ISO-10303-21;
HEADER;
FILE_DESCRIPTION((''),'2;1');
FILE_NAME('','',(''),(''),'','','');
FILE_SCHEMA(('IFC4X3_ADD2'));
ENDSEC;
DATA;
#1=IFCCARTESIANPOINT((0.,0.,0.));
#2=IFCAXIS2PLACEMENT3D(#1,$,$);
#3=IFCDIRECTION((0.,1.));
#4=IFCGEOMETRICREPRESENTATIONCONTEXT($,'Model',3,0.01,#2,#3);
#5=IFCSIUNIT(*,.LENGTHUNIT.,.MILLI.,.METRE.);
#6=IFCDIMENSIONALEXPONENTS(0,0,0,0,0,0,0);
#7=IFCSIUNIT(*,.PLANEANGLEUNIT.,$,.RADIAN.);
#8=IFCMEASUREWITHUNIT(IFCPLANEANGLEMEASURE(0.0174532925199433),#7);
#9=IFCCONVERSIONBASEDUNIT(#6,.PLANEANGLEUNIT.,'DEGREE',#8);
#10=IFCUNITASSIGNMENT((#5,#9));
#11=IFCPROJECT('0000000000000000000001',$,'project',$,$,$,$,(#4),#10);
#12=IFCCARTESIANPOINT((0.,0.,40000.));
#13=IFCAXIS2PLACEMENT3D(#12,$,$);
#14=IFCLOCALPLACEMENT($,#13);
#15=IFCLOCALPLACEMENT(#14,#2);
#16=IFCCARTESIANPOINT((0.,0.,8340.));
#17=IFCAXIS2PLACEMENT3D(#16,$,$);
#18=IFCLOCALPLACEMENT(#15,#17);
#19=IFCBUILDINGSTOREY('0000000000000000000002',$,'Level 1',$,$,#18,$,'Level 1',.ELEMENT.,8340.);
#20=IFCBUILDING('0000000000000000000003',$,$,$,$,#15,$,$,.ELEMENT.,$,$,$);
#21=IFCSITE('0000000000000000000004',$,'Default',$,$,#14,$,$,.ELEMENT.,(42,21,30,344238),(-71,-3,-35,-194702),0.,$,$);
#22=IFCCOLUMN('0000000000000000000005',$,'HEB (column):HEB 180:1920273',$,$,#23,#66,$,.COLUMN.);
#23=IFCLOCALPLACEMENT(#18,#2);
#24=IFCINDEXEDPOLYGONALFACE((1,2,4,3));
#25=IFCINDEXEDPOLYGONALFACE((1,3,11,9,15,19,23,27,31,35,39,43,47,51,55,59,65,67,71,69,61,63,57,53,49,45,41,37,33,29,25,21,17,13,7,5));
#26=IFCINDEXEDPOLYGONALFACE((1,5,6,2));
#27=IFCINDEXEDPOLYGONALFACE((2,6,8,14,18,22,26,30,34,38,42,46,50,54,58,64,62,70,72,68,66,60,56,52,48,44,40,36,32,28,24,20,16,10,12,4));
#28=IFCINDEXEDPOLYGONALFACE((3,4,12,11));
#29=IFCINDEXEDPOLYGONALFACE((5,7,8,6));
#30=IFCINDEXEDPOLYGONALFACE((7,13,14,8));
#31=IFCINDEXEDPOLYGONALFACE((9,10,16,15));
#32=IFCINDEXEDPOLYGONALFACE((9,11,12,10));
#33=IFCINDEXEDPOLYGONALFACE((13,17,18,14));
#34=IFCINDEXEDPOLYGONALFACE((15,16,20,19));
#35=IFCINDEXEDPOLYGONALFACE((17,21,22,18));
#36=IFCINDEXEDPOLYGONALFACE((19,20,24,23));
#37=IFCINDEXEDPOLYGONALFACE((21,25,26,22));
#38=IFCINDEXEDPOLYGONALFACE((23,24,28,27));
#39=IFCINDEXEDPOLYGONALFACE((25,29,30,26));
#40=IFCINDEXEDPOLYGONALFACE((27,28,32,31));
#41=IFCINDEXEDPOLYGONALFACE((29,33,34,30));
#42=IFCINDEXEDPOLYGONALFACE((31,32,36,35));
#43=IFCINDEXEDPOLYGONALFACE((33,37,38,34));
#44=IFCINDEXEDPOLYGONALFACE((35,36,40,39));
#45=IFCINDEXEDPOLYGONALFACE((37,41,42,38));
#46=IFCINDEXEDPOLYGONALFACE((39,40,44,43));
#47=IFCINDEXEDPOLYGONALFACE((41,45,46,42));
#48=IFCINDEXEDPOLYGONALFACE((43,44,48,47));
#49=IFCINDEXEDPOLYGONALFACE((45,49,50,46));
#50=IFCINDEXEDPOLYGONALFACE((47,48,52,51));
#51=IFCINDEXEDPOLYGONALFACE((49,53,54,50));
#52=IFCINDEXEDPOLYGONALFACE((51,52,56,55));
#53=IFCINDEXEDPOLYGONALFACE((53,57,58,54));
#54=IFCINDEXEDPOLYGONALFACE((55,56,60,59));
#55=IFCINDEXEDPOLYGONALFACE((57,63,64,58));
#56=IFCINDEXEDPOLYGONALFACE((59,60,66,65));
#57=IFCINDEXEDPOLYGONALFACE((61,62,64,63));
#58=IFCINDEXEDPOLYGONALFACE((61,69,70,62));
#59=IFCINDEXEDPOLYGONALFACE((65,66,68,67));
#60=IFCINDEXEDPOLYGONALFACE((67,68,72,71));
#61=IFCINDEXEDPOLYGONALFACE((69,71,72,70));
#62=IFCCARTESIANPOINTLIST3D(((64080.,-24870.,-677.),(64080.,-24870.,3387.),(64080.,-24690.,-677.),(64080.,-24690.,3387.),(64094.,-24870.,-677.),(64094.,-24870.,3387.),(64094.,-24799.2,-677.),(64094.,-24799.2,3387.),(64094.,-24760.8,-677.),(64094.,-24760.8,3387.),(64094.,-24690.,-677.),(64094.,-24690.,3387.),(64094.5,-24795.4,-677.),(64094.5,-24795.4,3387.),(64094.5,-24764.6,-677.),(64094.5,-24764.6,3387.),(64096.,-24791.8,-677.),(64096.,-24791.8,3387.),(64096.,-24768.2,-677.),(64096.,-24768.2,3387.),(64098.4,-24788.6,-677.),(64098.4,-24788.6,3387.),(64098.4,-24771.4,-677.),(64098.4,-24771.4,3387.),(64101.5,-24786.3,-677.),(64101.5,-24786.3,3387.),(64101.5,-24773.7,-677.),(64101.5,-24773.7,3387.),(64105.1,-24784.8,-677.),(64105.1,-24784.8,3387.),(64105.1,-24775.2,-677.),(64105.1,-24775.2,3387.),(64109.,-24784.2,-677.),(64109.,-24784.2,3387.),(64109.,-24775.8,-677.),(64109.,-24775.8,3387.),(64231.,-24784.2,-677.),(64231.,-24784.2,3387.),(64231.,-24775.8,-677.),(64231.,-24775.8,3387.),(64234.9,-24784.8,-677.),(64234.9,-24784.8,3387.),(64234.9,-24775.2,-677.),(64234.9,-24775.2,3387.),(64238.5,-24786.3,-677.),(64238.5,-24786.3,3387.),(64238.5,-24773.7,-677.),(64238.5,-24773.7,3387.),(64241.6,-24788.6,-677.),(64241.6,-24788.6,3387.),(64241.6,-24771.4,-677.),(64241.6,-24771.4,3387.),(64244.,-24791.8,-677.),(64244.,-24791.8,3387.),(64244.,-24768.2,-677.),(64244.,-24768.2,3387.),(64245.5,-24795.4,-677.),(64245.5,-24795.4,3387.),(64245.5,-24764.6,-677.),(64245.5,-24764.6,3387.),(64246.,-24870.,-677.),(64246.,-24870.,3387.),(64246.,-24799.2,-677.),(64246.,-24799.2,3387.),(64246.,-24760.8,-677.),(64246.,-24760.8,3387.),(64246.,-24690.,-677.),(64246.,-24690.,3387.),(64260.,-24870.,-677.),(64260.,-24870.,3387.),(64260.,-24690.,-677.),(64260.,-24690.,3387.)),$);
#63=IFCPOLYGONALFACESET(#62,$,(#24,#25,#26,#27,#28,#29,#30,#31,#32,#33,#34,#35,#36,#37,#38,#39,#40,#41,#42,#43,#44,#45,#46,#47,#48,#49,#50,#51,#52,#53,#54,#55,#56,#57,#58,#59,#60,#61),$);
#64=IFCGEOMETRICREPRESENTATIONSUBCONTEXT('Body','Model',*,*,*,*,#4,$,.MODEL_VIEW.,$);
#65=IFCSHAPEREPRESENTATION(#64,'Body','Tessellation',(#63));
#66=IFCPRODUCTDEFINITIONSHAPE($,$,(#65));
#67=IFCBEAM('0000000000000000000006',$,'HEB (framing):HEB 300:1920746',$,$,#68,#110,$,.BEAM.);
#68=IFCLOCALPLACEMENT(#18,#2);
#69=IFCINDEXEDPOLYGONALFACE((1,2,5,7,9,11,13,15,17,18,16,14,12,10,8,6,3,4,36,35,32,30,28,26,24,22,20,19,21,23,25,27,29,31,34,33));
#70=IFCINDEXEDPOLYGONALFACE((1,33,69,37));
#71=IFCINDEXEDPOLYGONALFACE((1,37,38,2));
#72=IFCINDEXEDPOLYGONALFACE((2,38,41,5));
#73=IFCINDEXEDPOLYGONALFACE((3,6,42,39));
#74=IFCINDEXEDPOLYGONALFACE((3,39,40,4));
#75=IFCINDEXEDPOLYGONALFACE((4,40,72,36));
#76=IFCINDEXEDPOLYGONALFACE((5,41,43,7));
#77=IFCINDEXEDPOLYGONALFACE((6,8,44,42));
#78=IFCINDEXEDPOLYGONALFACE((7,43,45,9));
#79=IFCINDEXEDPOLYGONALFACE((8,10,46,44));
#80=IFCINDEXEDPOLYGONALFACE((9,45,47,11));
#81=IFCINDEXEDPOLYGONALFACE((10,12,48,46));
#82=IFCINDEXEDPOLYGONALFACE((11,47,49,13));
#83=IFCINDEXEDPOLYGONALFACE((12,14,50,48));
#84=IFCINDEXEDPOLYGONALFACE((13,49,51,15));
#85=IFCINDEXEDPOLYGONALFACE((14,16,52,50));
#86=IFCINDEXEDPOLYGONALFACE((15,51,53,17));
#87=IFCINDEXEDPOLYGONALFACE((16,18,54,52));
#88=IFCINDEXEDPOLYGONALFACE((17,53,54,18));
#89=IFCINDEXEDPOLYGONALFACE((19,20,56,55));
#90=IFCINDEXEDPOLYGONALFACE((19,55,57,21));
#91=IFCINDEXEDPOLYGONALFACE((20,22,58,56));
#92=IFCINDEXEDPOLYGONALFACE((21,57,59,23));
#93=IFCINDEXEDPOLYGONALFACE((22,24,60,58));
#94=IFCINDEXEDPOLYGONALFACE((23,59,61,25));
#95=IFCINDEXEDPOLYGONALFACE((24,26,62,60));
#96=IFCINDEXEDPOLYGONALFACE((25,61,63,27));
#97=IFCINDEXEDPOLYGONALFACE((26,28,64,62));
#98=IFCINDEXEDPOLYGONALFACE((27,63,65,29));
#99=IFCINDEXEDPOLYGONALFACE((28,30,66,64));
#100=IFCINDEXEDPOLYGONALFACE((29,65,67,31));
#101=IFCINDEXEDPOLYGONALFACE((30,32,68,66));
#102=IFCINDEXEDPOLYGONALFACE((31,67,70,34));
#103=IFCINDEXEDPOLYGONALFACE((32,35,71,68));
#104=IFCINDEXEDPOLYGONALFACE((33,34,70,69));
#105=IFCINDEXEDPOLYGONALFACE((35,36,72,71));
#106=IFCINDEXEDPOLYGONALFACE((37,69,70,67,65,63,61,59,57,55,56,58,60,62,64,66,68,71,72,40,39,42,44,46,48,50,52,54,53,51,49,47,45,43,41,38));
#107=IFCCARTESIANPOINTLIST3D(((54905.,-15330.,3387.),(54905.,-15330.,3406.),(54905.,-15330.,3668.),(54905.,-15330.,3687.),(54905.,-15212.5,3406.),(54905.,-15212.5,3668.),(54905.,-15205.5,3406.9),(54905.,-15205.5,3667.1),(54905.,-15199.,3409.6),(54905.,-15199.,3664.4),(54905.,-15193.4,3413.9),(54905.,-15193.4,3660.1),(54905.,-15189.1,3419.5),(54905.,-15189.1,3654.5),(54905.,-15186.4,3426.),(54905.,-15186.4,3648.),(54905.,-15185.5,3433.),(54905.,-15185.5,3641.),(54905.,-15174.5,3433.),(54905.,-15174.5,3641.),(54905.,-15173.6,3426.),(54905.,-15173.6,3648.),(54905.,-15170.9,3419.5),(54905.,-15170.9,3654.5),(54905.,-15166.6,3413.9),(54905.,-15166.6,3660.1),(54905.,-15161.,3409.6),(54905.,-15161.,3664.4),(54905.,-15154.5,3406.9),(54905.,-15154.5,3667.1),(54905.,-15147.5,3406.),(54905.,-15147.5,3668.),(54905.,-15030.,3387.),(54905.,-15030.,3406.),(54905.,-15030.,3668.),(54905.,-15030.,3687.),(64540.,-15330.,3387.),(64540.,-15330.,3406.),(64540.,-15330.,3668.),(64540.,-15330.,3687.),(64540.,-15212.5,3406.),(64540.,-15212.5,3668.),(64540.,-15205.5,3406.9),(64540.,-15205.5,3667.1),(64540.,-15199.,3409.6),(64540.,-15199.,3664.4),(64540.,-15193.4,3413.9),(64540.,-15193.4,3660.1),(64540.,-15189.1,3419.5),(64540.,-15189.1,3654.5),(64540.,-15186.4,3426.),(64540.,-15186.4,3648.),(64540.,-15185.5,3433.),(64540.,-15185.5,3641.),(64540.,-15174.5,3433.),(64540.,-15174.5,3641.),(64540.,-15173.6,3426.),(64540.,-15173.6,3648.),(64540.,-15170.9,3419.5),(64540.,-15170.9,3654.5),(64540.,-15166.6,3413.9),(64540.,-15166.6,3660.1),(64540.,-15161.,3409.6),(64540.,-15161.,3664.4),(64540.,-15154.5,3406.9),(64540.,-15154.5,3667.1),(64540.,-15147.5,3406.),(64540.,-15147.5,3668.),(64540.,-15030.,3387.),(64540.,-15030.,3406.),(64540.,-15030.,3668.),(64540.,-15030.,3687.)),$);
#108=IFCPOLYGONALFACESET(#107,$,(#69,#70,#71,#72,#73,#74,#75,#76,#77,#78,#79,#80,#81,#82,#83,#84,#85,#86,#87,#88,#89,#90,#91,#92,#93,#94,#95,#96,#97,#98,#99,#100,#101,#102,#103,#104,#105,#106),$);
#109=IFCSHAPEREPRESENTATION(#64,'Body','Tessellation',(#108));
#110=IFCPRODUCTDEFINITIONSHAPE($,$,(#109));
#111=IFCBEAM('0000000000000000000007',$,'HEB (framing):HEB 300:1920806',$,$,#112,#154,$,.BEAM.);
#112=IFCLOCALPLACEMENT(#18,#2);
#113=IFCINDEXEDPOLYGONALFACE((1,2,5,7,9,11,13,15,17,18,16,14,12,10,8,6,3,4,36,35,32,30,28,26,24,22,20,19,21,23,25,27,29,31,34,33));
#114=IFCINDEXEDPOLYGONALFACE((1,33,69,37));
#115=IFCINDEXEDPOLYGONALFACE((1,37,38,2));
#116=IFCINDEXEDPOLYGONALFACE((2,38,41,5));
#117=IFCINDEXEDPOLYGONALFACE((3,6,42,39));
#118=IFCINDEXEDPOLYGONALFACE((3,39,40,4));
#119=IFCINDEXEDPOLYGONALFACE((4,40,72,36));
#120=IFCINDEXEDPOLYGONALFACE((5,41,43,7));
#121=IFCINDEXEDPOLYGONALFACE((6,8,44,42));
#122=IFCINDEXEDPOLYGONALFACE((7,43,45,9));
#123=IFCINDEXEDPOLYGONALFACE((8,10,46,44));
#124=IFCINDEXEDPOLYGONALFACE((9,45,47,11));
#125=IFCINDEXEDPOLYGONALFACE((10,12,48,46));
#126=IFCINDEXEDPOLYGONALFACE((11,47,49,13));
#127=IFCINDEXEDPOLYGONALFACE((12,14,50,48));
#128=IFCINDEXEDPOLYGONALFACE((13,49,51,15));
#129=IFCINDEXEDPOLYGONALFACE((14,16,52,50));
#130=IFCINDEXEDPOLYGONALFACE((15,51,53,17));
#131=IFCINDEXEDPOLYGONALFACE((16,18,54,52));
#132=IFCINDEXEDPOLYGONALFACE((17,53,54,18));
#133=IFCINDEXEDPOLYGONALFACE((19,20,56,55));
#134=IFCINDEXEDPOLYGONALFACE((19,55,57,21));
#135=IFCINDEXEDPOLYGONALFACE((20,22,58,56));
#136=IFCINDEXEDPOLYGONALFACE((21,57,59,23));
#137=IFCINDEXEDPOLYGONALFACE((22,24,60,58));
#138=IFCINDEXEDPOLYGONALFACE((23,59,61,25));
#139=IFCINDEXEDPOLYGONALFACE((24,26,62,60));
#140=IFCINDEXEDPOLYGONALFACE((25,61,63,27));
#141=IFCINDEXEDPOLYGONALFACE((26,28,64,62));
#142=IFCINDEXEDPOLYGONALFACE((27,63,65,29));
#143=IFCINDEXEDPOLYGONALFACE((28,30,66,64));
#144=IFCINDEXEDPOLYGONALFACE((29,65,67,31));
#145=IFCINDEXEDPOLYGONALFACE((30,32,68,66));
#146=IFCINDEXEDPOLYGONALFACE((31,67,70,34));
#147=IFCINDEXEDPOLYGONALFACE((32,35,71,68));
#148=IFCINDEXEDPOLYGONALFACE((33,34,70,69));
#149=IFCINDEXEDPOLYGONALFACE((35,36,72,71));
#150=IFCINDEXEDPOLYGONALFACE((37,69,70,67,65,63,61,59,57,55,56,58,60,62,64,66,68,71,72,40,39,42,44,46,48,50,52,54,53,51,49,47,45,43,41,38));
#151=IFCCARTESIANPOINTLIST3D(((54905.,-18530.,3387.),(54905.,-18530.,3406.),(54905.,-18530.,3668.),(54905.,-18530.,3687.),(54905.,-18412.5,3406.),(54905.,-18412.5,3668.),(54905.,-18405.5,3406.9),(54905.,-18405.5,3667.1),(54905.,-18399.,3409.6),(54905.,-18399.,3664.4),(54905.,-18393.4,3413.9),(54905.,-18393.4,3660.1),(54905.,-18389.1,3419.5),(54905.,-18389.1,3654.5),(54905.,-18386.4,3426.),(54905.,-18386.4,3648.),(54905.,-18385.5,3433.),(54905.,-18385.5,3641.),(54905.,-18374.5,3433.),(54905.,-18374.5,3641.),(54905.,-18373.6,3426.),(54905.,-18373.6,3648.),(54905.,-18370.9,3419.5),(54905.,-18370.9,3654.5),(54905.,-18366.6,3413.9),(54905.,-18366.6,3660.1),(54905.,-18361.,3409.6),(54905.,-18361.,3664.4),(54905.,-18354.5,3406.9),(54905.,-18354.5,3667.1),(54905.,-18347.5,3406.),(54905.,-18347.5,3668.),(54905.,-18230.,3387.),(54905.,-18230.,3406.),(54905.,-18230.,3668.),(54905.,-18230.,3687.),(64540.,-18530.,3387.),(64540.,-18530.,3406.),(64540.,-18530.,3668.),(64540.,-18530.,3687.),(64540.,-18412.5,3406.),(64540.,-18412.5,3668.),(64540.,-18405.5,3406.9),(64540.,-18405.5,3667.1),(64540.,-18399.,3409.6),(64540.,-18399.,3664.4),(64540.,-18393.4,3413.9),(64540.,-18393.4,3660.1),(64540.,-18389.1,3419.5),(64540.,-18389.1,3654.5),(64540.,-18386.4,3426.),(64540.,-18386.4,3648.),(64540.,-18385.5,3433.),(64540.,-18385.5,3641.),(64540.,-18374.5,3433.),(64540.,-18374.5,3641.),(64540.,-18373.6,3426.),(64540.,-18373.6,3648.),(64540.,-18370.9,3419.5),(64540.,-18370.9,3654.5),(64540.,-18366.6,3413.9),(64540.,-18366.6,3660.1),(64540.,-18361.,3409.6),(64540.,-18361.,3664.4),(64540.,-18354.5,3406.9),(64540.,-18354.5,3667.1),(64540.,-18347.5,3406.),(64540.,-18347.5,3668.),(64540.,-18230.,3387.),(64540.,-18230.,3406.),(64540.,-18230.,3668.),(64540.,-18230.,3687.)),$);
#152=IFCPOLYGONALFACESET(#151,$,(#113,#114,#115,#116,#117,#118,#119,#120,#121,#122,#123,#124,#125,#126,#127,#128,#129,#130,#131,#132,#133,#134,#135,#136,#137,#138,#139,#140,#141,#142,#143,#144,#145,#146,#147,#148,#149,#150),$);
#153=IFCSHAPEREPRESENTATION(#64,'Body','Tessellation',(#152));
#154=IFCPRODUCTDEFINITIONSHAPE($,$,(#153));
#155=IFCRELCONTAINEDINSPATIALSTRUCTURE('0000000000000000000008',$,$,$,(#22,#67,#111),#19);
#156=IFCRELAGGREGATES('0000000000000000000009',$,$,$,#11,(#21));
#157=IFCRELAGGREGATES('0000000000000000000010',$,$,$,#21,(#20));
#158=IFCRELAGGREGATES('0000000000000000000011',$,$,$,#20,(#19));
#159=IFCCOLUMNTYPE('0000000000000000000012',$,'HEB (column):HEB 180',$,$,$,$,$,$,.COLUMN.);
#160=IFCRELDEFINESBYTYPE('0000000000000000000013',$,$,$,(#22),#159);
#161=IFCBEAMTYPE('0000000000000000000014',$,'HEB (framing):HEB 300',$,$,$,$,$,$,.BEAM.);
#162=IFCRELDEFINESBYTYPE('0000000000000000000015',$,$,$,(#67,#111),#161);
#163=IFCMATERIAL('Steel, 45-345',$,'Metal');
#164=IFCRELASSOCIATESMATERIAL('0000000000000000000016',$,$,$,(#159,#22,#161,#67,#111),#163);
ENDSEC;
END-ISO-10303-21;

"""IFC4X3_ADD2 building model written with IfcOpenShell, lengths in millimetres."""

from ifc_helpers import new_model, entity, si_unit, converted_unit, direction, frame, frame_2d, origin, origin_2d_with_axis, place, context, subcontext, project, spatial, polyline, circle_curve, parameter, trimmed, segment, composite_curve, i_section, outline, extrude, source, transform, mapped, material, material_profile, profile_set, profile_usage, type_object, type_shapes, element, save


model = new_model("IFC4X3_ADD2")

# Units and contexts
model_context = context("Model", 3, precision=0.01, world=origin(), true_north=direction((0.0, 1.0)))
body_context = subcontext(model_context, "Body", "Model", "MODEL_VIEW")
ifc_project = project(units=[si_unit("LENGTHUNIT", "METRE", prefix="MILLI"), converted_unit("PLANEANGLEUNIT", "DEGREE", entity("IfcPlaneAngleMeasure", 0.0174532925199433), si_unit("PLANEANGLEUNIT", "RADIAN"), dimensions=[0, 0, 0, 0, 0, 0, 0])], contexts=[model_context])

# Site, building, storey
site_placement = place(None, frame((0.0, 0.0, 40000.0)))
site = spatial("IfcSite", under=ifc_project, at=site_placement, Name="Default", CompositionType="ELEMENT", RefLatitude=(42, 21, 30, 344238), RefLongitude=(-71, -3, -35, -194702), RefElevation=0.0)
building_placement = place(site_placement, origin())
building = spatial("IfcBuilding", under=site, at=building_placement, CompositionType="ELEMENT")
storey_placement = place(building_placement, frame((0.0, 0.0, 8340.0)))
storey = spatial("IfcBuildingStorey", under=building, at=storey_placement, Name="Level 1", LongName="Level 1", CompositionType="ELEMENT", Elevation=8340.0)

# Column
ifc_material_1 = material(Name="Steel, 45-345", Category="Metal")
ifc_material_profile_1 = material_profile(ifc_material_1, i_section(OverallWidth=180.0, OverallDepth=180.0, WebThickness=8.5, FlangeThickness=14.0, FilletRadius=15.0, at=origin_2d_with_axis()), Name="HEB 180")
ifc_profile_set_1 = profile_set([ifc_material_profile_1], Name="HEB 180")
ifc_profile_usage_1 = profile_usage(ifc_profile_set_1)
column_type_1 = type_object("IfcColumnType", Name="HEB (column):HEB 180", PredefinedType="COLUMN", material=ifc_profile_set_1)
shared_shape_1 = source(origin(), body_context, "Body", "SweptSolid", [
    extrude(i_section(OverallWidth=180.0, OverallDepth=180.0, WebThickness=8.5, FlangeThickness=14.0, FilletRadius=15.0, at=origin_2d_with_axis()), frame((0.0, 0.0, 7663.0), z_axis=(0.0, 0.0, 1.0), x_axis=(-1.0, 0.0, 0.0)), (0.0, 0.0, 1.0), 4064.0),
])
type_shapes(column_type_1, [shared_shape_1])
column_placement = place(storey_placement, frame((64170.0, -24780.0, -8340.0), z_axis=(0.0, 0.0, 1.0), x_axis=(0.0, -1.0, 0.0)))
element("IfcColumn", 1, at=column_placement, inside=storey, type_object=column_type_1, material=ifc_profile_usage_1, Name="HEB (column):HEB 180:1920273", PredefinedType="COLUMN", context=body_context, shape_type="MappedRepresentation", body=[
    mapped(shared_shape_1, transform((0.0, 0.0, 0.0), scale=1.0)),
])

# Beams
ifc_material_profile_2 = material_profile(ifc_material_1, outline(composite_curve([segment(polyline([(-150.0, -131.0), (-150.0, -150.0)]), True, "CONTINUOUS"), segment(polyline([(-150.0, -150.0), (150.0, -150.0)]), True, "CONTINUOUS"), segment(polyline([(150.0, -150.0), (150.0, -131.0)]), True, "CONTINUOUS"), segment(polyline([(150.0, -131.0), (32.5, -131.0)]), True, "CONTINUOUS"), segment(trimmed(circle_curve(frame_2d((32.5, -104.0), x_axis=(1.0, 0.0)), 27.0), [parameter(180.0)], [parameter(270.0)], True, "PARAMETER"), False, "CONTINUOUS"), segment(polyline([(5.5, -104.0), (5.5, 104.0)]), True, "CONTINUOUS"), segment(trimmed(circle_curve(frame_2d((32.5, 104.0), x_axis=(1.0, 0.0)), 27.0), [parameter(90.0)], [parameter(180.0)], True, "PARAMETER"), False, "CONTINUOUS"), segment(polyline([(32.5, 131.0), (150.0, 131.0)]), True, "CONTINUOUS"), segment(polyline([(150.0, 131.0), (150.0, 150.0)]), True, "CONTINUOUS"), segment(polyline([(150.0, 150.0), (-150.0, 150.0)]), True, "CONTINUOUS"), segment(polyline([(-150.0, 150.0), (-150.0, 131.0)]), True, "CONTINUOUS"), segment(polyline([(-150.0, 131.0), (-32.5, 131.0)]), True, "CONTINUOUS"), segment(trimmed(circle_curve(frame_2d((-32.5, 104.0), x_axis=(1.0, 0.0)), 27.0), [parameter(360.0)], [parameter(90.0)], True, "PARAMETER"), False, "CONTINUOUS"), segment(polyline([(-5.5, 104.0), (-5.5, -104.0)]), True, "CONTINUOUS"), segment(trimmed(circle_curve(frame_2d((-32.5, -104.0), x_axis=(1.0, 0.0)), 27.0), [parameter(270.0)], [parameter(0.0)], True, "PARAMETER"), False, "CONTINUOUS"), segment(polyline([(-32.5, -131.0), (-150.0, -131.0)]), True, "CONTINUOUS")], self_intersect=False)), Name="HEB 300")
ifc_profile_set_2 = profile_set([ifc_material_profile_2], Name="HEB 300")
ifc_profile_usage_2 = profile_usage(ifc_profile_set_2, cardinal=8)
beam_type_1 = type_object("IfcBeamType", Name="HEB (framing):HEB 300", PredefinedType="BEAM", material=ifc_profile_set_2)
shared_shape_2 = source(origin(), body_context, "Body", "SweptSolid", [
    extrude(outline(composite_curve([segment(polyline([(-150.0, -131.0), (-150.0, -150.0)]), True, "CONTINUOUS"), segment(polyline([(-150.0, -150.0), (150.0, -150.0)]), True, "CONTINUOUS"), segment(polyline([(150.0, -150.0), (150.0, -131.0)]), True, "CONTINUOUS"), segment(polyline([(150.0, -131.0), (32.5, -131.0)]), True, "CONTINUOUS"), segment(trimmed(circle_curve(frame_2d((32.5, -104.0), x_axis=(1.0, 0.0)), 27.0), [parameter(180.0)], [parameter(270.0)], True, "PARAMETER"), False, "CONTINUOUS"), segment(polyline([(5.5, -104.0), (5.5, 104.0)]), True, "CONTINUOUS"), segment(trimmed(circle_curve(frame_2d((32.5, 104.0), x_axis=(1.0, 0.0)), 27.0), [parameter(90.0)], [parameter(180.0)], True, "PARAMETER"), False, "CONTINUOUS"), segment(polyline([(32.5, 131.0), (150.0, 131.0)]), True, "CONTINUOUS"), segment(polyline([(150.0, 131.0), (150.0, 150.0)]), True, "CONTINUOUS"), segment(polyline([(150.0, 150.0), (-150.0, 150.0)]), True, "CONTINUOUS"), segment(polyline([(-150.0, 150.0), (-150.0, 131.0)]), True, "CONTINUOUS"), segment(polyline([(-150.0, 131.0), (-32.5, 131.0)]), True, "CONTINUOUS"), segment(trimmed(circle_curve(frame_2d((-32.5, 104.0), x_axis=(1.0, 0.0)), 27.0), [parameter(360.0)], [parameter(90.0)], True, "PARAMETER"), False, "CONTINUOUS"), segment(polyline([(-5.5, 104.0), (-5.5, -104.0)]), True, "CONTINUOUS"), segment(trimmed(circle_curve(frame_2d((-32.5, -104.0), x_axis=(1.0, 0.0)), 27.0), [parameter(270.0)], [parameter(0.0)], True, "PARAMETER"), False, "CONTINUOUS"), segment(polyline([(-32.5, -131.0), (-150.0, -131.0)]), True, "CONTINUOUS")], self_intersect=False)), frame((-4782.5, 0.0, 0.0), z_axis=(-1.0, 0.0, 0.0), x_axis=(0.0, -1.0, 0.0)), (0.0, 0.0, -1.0), 9635.0),
])
type_shapes(beam_type_1, [shared_shape_2])
for number, where, name in (
    (2, (59687.5, -15180.0, 3537.0), "HEB (framing):HEB 300:1920746"),
    (3, (59687.5, -18380.0, 3537.0), "HEB (framing):HEB 300:1920806"),
):
    element("IfcBeam", number, at=place(storey_placement, frame(where)), inside=storey, type_object=beam_type_1, material=ifc_profile_usage_2, Name=name, PredefinedType="BEAM", context=body_context, shape_type="MappedRepresentation", body=[
        mapped(shared_shape_2, transform((0.0, 0.0, 0.0), scale=1.0)),
    ])

save(model, "model.ifc")
